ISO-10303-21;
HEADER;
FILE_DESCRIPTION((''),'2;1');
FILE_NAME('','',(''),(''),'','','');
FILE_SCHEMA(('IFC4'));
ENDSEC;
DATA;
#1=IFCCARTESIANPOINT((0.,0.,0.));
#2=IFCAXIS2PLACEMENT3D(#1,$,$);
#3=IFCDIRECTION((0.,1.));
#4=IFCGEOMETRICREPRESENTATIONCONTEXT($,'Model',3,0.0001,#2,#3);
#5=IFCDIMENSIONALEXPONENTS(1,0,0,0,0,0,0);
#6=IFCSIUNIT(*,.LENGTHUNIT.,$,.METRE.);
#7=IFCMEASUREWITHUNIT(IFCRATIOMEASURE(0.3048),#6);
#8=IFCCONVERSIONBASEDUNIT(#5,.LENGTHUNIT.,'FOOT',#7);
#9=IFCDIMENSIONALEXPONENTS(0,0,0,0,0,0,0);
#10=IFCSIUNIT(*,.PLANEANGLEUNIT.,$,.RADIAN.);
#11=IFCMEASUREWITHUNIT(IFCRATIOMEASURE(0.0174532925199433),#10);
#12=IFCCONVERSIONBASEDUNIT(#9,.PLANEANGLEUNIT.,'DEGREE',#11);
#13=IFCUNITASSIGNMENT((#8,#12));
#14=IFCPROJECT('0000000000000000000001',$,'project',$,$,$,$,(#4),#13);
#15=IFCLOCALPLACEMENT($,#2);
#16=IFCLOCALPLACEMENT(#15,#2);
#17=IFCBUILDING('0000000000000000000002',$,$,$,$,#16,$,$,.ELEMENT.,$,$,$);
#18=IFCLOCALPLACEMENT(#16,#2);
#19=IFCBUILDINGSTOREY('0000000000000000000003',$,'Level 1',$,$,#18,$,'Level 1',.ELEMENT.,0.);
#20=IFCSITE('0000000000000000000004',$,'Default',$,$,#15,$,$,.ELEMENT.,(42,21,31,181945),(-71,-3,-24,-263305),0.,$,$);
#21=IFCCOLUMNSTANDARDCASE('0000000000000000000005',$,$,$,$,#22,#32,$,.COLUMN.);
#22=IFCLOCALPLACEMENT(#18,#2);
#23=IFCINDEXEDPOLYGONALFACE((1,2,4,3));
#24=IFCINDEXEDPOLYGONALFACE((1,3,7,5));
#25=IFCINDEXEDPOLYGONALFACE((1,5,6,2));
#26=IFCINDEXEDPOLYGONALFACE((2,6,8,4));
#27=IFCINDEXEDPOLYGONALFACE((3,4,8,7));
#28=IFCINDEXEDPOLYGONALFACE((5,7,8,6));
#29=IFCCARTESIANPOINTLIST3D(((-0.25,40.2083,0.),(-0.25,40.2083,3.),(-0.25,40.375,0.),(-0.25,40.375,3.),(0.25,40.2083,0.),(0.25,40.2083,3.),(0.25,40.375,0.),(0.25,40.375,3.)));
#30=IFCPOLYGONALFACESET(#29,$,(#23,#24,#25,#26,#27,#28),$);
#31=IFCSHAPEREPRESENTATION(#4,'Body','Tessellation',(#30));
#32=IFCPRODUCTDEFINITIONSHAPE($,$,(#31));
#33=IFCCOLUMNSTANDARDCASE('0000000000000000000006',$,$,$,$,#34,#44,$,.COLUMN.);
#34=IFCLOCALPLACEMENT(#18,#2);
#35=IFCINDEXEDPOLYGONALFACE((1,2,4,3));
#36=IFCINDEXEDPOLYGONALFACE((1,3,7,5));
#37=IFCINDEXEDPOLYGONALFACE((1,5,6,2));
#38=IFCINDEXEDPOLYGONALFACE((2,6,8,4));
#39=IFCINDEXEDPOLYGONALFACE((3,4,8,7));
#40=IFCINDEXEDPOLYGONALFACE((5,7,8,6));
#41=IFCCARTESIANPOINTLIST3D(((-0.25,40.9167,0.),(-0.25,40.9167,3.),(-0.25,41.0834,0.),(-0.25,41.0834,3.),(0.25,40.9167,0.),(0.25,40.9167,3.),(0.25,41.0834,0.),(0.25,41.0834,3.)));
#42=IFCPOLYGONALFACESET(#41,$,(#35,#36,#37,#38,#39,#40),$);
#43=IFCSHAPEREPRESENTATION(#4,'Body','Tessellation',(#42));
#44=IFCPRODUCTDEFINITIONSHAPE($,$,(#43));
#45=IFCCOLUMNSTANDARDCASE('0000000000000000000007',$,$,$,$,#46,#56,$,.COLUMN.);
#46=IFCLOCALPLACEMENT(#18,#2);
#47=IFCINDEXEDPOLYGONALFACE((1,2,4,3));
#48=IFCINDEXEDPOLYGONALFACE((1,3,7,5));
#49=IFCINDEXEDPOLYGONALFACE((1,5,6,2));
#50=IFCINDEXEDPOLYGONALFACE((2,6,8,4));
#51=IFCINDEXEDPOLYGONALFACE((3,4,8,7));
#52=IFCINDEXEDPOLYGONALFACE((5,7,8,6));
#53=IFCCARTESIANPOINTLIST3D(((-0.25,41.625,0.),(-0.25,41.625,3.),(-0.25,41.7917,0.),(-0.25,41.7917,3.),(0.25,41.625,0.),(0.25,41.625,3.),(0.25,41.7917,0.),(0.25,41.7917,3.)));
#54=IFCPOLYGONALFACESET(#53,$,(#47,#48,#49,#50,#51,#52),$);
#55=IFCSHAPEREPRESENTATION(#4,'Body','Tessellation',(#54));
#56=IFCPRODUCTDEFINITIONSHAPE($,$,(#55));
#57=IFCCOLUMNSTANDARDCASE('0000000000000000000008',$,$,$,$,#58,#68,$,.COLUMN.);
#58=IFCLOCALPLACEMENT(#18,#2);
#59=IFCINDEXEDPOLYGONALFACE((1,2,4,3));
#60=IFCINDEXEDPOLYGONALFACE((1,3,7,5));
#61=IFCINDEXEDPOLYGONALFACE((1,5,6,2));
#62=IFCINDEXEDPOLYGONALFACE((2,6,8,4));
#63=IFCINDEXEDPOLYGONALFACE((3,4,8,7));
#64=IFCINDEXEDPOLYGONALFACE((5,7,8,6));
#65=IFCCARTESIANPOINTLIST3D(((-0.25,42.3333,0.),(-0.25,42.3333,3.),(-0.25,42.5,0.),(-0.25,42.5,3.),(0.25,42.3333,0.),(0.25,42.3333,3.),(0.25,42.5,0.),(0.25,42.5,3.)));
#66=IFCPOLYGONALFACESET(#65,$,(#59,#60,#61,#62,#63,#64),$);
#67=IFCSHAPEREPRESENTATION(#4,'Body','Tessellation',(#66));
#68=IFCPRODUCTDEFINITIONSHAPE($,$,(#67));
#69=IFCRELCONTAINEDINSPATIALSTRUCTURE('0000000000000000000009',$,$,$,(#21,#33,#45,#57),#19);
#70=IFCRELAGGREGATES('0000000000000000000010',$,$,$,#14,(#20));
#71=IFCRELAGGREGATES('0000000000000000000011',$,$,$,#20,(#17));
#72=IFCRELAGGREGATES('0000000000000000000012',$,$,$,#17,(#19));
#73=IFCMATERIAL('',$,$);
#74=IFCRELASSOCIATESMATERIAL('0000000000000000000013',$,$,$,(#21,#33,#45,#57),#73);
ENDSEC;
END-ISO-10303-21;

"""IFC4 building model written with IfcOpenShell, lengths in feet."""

from ifc_helpers import new_model, entity, si_unit, converted_unit, direction, frame, origin, place, context, project, spatial, rectangle, extrude, material, element, save


model = new_model("IFC4")

# Units and contexts
model_context = context("Model", 3, precision=0.0001, world=origin(), true_north=direction((0.0, 1.0)))
ifc_project = project(units=[converted_unit("LENGTHUNIT", "FOOT", entity("IfcRatioMeasure", 0.3048), si_unit("LENGTHUNIT", "METRE"), dimensions=[1, 0, 0, 0, 0, 0, 0]), converted_unit("PLANEANGLEUNIT", "DEGREE", entity("IfcRatioMeasure", 0.0174532925199433), si_unit("PLANEANGLEUNIT", "RADIAN"), dimensions=[0, 0, 0, 0, 0, 0, 0])], contexts=[model_context])

# Site, building, storey
site_placement = place(None, origin())
site = spatial("IfcSite", under=ifc_project, at=site_placement, Name="Default", CompositionType="ELEMENT", RefLatitude=(42, 21, 31, 181945), RefLongitude=(-71, -3, -24, -263305), RefElevation=0.0)
building_placement = place(site_placement, origin())
building = spatial("IfcBuilding", under=site, at=building_placement, CompositionType="ELEMENT")
storey_placement = place(building_placement, origin())
storey = spatial("IfcBuildingStorey", under=building, at=storey_placement, Name="Level 1", LongName="Level 1", CompositionType="ELEMENT", Elevation=0.0)

# Columns
placement = place(storey_placement, frame((0.0, -0.25, 0.0), z_axis=(0.0, 0.0, 1.0), x_axis=(0.0, 1.0, 0.0)))
ifc_material_1 = material(Name="")
for number, where, z_axis, x_axis in (
    (1, (40.5417, 0.0, 0.0), (0.0, 0.0, 1.0), (1.0, 0.0, 0.0)),
    (2, (41.25, 0.0, 0.0), (0.0, 0.0, 1.0), (1.0, 0.0, 0.0)),
    (3, (41.9583, 0.0, 0.0), (0.0, 0.0, 1.0), (1.0, 0.0, 0.0)),
    (4, (42.6667, 0.0, 0.0), (0.0, 0.0, 1.0), (1.0, 0.0, 0.0)),
):
    element("IfcColumnStandardCase", number, at=place(placement, frame(where, z_axis=z_axis, x_axis=x_axis)), inside=storey, material=ifc_material_1, PredefinedType="COLUMN", context=model_context, shape_type="SweptSolid", body=[
        extrude(rectangle(XDim=0.1667, YDim=0.5), origin(), (0.0, 0.0, 1.0), 3.0),
    ])

save(model, "model.ifc")
